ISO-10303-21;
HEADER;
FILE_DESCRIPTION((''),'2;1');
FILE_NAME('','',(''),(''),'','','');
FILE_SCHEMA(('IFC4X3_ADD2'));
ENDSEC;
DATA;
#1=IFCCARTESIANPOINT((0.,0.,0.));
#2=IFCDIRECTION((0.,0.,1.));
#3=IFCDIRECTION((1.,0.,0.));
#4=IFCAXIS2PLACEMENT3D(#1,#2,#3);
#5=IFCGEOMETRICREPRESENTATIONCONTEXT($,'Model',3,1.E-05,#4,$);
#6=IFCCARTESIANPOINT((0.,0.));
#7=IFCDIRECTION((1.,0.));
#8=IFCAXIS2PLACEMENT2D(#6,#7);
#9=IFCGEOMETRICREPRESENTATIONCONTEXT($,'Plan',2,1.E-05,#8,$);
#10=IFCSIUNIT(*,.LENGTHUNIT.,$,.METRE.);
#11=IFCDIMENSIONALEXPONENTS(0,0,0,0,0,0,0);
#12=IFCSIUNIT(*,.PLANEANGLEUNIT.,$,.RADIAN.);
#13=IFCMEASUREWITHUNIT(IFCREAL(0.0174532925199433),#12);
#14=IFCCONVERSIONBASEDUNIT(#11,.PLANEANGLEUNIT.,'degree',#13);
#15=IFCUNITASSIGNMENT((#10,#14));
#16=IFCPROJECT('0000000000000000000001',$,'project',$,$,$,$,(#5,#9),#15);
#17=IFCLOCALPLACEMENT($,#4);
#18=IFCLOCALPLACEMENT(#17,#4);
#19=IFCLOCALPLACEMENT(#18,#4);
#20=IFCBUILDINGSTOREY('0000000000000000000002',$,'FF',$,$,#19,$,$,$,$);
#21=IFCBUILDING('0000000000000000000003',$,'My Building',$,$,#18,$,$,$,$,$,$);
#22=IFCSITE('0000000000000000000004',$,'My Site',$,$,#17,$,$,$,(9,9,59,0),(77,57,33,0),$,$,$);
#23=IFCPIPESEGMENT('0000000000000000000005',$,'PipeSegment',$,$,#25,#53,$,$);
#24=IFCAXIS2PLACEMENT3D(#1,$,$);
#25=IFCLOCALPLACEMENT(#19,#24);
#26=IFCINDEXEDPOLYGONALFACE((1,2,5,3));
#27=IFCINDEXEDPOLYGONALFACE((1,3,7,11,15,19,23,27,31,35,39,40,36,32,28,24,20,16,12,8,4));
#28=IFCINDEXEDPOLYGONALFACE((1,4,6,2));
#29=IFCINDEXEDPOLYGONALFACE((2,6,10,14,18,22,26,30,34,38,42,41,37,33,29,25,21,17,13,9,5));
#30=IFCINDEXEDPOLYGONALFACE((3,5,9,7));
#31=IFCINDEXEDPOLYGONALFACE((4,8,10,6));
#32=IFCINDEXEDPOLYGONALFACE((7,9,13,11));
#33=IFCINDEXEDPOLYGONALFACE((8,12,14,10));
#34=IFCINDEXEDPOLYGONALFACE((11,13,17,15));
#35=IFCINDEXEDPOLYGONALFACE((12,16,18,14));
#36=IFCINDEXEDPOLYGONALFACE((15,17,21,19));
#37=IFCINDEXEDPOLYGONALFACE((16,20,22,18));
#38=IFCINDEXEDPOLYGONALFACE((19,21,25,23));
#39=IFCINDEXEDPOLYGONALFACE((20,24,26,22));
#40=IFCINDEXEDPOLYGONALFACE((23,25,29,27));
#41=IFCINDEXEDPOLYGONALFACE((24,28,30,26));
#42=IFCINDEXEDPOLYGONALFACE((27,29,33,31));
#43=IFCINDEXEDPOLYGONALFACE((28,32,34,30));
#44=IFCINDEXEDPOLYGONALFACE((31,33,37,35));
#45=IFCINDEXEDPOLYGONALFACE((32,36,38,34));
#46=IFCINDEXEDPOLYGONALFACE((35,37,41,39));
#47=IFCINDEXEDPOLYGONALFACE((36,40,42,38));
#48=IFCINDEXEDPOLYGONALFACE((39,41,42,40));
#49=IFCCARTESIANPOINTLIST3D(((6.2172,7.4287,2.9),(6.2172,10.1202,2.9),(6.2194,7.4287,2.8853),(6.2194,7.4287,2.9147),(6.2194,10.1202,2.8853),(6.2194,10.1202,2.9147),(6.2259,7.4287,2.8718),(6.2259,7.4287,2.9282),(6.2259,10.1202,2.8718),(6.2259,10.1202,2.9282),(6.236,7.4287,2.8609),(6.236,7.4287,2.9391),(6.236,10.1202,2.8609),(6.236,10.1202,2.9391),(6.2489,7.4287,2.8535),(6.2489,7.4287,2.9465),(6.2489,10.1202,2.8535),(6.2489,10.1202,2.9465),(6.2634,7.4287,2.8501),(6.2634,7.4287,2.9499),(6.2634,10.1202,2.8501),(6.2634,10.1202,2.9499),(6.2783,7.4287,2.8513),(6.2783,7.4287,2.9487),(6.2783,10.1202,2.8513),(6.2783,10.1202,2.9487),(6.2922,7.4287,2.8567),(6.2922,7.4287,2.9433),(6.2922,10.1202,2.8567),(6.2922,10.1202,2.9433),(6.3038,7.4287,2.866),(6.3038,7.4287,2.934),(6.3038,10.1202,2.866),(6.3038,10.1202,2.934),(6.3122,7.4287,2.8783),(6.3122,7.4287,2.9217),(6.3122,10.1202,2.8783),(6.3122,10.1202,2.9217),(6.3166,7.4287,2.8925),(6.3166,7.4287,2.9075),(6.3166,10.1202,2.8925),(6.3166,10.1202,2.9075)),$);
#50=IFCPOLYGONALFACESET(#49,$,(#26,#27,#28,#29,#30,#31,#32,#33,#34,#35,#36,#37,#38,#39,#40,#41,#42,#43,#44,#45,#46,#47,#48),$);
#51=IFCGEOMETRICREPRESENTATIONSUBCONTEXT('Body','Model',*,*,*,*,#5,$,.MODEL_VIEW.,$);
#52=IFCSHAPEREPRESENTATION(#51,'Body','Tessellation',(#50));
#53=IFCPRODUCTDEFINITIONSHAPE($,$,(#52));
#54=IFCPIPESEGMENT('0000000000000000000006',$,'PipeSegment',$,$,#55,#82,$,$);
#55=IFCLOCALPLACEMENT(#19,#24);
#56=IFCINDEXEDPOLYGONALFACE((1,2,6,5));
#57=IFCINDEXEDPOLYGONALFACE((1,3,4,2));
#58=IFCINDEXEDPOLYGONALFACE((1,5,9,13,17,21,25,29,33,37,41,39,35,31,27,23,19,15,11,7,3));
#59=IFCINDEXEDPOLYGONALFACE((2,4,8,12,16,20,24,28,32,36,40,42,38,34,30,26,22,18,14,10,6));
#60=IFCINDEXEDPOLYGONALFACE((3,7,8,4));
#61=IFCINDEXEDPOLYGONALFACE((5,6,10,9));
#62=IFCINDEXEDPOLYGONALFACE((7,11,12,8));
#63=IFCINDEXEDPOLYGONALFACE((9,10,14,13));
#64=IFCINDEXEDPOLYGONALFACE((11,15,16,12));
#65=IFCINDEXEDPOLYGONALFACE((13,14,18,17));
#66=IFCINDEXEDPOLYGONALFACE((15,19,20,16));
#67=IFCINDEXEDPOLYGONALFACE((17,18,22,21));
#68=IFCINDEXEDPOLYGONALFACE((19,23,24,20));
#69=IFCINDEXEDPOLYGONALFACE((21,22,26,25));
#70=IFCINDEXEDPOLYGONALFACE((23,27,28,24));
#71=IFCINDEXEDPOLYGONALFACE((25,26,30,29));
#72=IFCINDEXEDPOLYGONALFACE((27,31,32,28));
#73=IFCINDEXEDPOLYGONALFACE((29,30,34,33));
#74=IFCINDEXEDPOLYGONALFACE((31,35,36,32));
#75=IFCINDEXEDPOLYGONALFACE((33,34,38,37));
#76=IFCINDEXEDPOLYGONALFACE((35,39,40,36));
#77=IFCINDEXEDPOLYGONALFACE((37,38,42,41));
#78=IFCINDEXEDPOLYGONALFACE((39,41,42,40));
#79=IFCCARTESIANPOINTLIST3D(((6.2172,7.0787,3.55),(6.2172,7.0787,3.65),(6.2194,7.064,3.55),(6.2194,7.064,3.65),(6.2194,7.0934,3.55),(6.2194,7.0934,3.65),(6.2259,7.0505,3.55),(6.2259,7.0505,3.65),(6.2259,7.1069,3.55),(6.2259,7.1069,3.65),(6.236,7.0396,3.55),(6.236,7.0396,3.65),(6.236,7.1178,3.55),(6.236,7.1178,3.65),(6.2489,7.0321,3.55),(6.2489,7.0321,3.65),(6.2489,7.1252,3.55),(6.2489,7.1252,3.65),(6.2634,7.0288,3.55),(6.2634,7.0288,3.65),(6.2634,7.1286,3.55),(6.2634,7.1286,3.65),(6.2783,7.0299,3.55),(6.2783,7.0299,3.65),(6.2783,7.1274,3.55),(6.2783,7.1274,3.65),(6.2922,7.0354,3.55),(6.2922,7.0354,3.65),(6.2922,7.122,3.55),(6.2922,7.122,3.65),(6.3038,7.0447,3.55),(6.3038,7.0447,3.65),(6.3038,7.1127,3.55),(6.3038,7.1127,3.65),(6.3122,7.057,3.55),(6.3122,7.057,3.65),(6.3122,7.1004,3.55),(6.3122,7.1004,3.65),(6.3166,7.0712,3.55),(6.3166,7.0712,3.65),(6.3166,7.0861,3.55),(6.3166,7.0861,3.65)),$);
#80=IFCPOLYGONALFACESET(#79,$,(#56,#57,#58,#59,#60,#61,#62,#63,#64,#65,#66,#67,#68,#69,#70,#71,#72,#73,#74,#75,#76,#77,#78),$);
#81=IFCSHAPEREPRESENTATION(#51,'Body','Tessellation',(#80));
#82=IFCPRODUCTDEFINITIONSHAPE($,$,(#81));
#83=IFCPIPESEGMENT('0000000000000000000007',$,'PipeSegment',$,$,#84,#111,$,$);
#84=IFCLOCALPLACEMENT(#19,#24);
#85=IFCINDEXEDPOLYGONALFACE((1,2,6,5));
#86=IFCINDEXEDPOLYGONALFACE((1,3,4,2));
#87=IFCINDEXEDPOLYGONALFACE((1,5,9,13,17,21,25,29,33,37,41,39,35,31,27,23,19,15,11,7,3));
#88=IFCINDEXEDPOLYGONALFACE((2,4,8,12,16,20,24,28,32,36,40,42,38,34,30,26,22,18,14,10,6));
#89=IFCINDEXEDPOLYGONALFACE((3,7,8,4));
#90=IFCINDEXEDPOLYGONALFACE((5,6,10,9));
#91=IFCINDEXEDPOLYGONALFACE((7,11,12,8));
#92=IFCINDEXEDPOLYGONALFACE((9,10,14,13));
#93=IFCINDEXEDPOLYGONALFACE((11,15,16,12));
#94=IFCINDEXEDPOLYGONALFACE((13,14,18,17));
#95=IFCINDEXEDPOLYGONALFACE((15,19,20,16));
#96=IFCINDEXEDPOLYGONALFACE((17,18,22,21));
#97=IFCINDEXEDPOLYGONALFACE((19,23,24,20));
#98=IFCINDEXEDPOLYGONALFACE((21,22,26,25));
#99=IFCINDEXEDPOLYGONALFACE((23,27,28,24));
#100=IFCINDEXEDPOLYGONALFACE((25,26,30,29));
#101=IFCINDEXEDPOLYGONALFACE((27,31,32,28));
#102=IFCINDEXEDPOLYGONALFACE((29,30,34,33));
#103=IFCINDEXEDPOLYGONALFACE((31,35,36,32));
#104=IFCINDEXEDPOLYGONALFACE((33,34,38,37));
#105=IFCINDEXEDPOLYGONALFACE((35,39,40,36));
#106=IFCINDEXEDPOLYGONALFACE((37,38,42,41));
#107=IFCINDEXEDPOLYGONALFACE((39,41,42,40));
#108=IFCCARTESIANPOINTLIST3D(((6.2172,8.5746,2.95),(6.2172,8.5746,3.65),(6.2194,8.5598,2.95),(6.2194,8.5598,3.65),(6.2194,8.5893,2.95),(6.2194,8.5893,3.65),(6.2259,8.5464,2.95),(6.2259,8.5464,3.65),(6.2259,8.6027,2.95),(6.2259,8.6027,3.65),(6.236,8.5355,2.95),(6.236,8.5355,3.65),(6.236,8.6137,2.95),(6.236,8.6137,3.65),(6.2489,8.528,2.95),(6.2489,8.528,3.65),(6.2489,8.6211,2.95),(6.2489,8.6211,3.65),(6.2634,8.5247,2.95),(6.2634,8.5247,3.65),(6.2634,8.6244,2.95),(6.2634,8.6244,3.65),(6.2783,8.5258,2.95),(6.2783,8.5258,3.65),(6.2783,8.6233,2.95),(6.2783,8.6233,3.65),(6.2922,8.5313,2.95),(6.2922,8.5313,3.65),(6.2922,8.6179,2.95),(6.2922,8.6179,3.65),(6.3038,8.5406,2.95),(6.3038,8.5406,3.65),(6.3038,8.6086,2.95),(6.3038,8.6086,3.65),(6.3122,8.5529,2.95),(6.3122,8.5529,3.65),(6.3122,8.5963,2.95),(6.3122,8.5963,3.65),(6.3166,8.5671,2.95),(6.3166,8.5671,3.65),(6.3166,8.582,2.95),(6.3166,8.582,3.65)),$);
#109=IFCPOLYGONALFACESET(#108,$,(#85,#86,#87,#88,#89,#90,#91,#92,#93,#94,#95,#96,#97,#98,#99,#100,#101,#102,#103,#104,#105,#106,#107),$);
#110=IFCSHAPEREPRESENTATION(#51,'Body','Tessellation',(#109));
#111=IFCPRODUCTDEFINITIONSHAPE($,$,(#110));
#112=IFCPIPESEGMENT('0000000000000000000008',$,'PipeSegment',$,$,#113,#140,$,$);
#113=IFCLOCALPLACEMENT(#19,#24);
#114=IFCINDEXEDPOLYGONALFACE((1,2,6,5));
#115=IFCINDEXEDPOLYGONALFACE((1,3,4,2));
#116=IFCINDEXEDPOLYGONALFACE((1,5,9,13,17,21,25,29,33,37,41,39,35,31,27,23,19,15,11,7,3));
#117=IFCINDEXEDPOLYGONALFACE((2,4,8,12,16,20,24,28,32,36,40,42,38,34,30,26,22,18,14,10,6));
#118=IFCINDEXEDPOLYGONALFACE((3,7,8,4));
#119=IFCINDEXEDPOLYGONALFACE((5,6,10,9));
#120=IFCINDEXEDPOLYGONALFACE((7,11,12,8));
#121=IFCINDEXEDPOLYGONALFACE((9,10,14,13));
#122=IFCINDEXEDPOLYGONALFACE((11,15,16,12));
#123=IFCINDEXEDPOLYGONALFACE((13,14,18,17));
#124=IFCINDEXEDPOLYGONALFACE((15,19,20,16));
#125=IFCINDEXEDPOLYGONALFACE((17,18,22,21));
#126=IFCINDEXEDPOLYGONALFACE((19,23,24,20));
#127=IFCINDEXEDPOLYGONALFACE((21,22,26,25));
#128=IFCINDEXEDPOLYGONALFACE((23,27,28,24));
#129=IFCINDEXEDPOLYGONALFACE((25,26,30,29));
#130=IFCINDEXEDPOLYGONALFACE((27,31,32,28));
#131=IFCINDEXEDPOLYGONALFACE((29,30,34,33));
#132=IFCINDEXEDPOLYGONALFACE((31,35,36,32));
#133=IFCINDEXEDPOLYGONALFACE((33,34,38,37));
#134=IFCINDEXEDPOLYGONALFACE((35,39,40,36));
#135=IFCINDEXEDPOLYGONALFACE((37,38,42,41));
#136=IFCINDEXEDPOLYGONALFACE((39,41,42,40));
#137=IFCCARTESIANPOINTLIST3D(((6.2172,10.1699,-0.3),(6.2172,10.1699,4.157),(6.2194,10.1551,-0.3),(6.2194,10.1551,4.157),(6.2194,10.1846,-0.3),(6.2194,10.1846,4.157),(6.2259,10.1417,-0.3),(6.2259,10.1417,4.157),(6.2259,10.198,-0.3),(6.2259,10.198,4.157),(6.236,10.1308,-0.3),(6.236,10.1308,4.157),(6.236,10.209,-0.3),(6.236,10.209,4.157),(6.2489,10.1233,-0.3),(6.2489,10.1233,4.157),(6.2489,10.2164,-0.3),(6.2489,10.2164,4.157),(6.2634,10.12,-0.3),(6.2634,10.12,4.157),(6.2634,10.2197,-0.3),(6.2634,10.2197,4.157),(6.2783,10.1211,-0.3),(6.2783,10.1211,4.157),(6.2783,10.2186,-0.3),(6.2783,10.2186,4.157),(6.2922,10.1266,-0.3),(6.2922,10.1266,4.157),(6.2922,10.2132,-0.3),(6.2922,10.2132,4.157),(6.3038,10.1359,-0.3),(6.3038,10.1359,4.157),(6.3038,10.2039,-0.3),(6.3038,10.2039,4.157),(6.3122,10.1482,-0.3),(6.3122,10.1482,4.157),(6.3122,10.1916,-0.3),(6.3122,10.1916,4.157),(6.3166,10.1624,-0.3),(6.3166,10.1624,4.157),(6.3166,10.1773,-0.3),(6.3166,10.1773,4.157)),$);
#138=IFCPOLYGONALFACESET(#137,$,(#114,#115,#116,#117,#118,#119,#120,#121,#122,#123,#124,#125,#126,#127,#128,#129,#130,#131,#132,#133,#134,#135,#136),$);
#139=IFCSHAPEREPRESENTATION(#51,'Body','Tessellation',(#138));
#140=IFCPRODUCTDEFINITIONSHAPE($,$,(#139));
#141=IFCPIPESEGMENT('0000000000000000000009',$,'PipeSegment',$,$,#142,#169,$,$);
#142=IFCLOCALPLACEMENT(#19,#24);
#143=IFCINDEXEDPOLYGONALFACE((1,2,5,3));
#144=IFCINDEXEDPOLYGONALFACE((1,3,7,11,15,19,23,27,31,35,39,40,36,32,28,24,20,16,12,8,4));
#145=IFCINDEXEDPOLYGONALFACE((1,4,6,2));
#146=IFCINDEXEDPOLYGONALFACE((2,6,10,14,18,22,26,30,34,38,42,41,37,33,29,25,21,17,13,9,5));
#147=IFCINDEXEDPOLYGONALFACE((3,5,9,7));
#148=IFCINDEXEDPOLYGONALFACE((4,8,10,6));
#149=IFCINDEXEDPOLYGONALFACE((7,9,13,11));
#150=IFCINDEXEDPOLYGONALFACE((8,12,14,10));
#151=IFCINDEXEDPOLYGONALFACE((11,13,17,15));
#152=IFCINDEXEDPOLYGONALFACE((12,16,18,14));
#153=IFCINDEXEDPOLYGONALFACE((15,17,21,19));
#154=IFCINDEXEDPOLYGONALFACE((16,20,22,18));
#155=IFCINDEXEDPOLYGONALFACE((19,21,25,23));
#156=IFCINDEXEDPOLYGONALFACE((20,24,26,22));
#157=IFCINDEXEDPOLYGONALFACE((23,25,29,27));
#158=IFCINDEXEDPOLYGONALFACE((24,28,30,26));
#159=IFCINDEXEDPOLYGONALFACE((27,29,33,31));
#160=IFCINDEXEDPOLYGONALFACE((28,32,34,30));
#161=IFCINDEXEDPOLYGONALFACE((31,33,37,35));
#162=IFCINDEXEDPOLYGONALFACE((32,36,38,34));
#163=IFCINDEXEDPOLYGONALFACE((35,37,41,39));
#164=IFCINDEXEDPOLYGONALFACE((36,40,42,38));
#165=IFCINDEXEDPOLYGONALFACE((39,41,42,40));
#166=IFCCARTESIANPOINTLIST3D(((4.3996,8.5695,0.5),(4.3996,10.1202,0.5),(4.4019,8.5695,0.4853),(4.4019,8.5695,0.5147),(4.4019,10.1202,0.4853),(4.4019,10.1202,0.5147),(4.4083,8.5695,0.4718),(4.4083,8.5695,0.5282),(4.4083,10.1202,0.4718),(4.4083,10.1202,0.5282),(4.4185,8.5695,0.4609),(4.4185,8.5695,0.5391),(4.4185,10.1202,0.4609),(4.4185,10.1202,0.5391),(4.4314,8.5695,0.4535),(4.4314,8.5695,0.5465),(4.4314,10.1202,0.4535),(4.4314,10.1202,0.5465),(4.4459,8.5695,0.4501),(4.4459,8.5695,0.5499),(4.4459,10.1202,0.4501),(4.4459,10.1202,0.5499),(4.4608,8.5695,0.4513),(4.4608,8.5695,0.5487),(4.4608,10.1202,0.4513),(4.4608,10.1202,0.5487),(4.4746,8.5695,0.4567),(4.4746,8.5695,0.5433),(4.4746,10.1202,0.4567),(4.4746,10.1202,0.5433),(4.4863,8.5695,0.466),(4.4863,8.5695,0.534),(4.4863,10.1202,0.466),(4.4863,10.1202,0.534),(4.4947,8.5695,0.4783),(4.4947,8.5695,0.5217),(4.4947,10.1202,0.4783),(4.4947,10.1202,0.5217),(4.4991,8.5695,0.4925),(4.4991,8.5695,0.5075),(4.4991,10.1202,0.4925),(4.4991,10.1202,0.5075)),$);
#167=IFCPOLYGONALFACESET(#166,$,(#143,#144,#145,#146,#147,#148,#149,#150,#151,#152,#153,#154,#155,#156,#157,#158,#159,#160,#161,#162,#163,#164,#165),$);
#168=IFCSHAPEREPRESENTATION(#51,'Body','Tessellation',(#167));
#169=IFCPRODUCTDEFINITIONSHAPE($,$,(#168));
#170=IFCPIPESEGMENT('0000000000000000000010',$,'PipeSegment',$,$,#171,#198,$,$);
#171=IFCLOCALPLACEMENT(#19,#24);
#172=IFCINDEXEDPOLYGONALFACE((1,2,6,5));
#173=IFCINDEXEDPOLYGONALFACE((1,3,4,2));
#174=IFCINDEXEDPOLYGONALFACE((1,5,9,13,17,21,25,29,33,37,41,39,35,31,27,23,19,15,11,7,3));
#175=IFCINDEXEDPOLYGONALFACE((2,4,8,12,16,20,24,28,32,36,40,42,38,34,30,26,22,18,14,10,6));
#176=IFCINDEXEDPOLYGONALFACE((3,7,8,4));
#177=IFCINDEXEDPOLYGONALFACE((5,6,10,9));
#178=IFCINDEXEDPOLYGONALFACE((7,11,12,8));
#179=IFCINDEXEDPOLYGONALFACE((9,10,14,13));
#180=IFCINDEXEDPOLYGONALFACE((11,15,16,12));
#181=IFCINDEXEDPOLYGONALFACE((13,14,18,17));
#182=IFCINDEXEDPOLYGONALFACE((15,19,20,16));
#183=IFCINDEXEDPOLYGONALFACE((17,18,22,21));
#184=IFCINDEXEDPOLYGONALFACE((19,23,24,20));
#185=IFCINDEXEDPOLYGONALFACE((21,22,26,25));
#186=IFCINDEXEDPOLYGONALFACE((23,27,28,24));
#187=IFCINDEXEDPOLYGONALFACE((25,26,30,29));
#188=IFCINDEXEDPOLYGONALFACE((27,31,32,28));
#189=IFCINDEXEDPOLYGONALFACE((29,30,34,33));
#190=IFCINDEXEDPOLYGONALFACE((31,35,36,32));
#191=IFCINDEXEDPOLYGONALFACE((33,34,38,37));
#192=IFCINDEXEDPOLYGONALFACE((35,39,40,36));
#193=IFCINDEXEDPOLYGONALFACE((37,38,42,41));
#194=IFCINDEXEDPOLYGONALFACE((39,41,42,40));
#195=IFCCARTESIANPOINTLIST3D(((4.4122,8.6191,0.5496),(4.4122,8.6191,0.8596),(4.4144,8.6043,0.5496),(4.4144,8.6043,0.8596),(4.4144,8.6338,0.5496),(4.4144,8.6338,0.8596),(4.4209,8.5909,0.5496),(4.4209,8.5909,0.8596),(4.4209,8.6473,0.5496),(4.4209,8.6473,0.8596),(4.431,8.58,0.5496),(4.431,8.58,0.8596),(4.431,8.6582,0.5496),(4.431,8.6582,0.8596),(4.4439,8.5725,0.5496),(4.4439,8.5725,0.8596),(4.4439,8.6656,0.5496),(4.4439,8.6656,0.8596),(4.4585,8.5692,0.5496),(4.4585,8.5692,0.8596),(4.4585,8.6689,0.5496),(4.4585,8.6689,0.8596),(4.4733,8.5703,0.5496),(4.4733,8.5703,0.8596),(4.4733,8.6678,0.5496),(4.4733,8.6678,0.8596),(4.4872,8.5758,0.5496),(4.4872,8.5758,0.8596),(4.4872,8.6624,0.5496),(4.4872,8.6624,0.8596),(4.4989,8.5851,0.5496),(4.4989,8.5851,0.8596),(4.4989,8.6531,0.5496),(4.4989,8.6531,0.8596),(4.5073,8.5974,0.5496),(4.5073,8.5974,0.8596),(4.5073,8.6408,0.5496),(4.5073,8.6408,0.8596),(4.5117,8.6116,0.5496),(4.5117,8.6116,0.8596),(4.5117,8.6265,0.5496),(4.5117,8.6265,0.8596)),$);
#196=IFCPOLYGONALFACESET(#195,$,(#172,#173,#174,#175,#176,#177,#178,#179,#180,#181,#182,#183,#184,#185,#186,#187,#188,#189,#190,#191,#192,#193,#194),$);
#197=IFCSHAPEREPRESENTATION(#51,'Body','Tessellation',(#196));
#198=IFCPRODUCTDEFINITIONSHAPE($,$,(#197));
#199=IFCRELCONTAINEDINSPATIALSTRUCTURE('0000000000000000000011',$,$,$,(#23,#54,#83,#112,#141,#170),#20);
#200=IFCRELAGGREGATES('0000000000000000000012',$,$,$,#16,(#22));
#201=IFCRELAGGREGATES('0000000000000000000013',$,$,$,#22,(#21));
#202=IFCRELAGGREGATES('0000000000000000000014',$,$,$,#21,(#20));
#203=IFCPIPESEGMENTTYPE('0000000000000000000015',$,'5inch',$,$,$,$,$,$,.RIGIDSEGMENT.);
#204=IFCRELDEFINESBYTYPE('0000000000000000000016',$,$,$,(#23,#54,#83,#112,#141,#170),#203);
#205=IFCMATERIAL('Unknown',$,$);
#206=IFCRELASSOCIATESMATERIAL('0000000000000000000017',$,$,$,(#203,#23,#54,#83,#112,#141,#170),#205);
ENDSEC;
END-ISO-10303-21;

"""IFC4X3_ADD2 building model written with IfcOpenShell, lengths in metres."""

from ifc_helpers import new_model, entity, si_unit, converted_unit, frame, origin_with_axes, origin_2d_with_axis, place, context, subcontext, project, spatial, circle, extrude, material, material_profile, profile_set, profile_usage, type_object, element, save


model = new_model("IFC4X3_ADD2")

# Units and contexts
model_context = context("Model", 3, precision=1e-05, world=origin_with_axes())
plan_context = context("Plan", 2, precision=1e-05, world=origin_2d_with_axis())
body_context_1 = subcontext(model_context, "Body", "Model", "MODEL_VIEW")
ifc_project = project(units=[si_unit("LENGTHUNIT", "METRE"), converted_unit("PLANEANGLEUNIT", "degree", entity("IfcReal", 0.0174532925199433), si_unit("PLANEANGLEUNIT", "RADIAN"), dimensions=[0, 0, 0, 0, 0, 0, 0])], contexts=[model_context, plan_context])

# Site, building, storey
site_placement = place(None, origin_with_axes())
site = spatial("IfcSite", under=ifc_project, at=site_placement, Name="My Site", RefLatitude=(9, 9, 59, 0), RefLongitude=(77, 57, 33, 0))
building_placement = place(site_placement, origin_with_axes())
building = spatial("IfcBuilding", under=site, at=building_placement, Name="My Building")
storey_placement = place(building_placement, origin_with_axes())
storey = spatial("IfcBuildingStorey", under=building, at=storey_placement, Name="FF")

# Shared definitions
ifc_material = material(Name="Unknown")

# Pipe segments
ifc_material_profile_1 = material_profile(ifc_material, circle(Radius=0.05))
ifc_profile_set_1 = profile_set([ifc_material_profile_1])
ifc_profile_usage_1 = profile_usage(ifc_profile_set_1, cardinal=5)
pipe_segment_type_1 = type_object("IfcPipeSegmentType", Name="5inch", PredefinedType="RIGIDSEGMENT", material=ifc_profile_set_1)
pipe_segment_1_placement = place(storey_placement, frame((6.2672, 7.4287, 2.9), z_axis=(0.0, 1.0, 0.0), x_axis=(-1.0, 0.0, 0.0)))
element("IfcPipeSegment", 1, at=pipe_segment_1_placement, inside=storey, type_object=pipe_segment_type_1, material=ifc_profile_usage_1, Name="PipeSegment", context=body_context_1, shape_type="SweptSolid", body=[
    extrude(circle(Radius=0.05), origin_with_axes(), (0.0, 0.0, 1.0), 2.6915),
])
ifc_profile_usage_2 = profile_usage(ifc_profile_set_1, cardinal=5)
pipe_segment_2_placement = place(storey_placement, frame((6.2672, 7.0787, 3.55), z_axis=(0.0, 0.0, 1.0), x_axis=(-1.0, 0.0, 0.0)))
element("IfcPipeSegment", 2, at=pipe_segment_2_placement, inside=storey, type_object=pipe_segment_type_1, material=ifc_profile_usage_2, Name="PipeSegment", context=body_context_1, shape_type="SweptSolid", body=[
    extrude(circle(Radius=0.05), origin_with_axes(), (0.0, 0.0, 1.0), 0.1),
])
ifc_profile_usage_3 = profile_usage(ifc_profile_set_1, cardinal=5)
pipe_segment_3_placement = place(storey_placement, frame((6.2672, 8.5746, 2.95), z_axis=(0.0, 0.0, 1.0), x_axis=(-1.0, 0.0, 0.0)))
element("IfcPipeSegment", 3, at=pipe_segment_3_placement, inside=storey, type_object=pipe_segment_type_1, material=ifc_profile_usage_3, Name="PipeSegment", context=body_context_1, shape_type="SweptSolid", body=[
    extrude(circle(Radius=0.05), origin_with_axes(), (0.0, 0.0, 1.0), 0.7),
])
ifc_profile_usage_4 = profile_usage(ifc_profile_set_1, cardinal=5)
pipe_segment_4_placement = place(storey_placement, frame((6.2672, 10.1699, -0.3), z_axis=(0.0, 0.0, 1.0), x_axis=(-1.0, 0.0, 0.0)))
element("IfcPipeSegment", 4, at=pipe_segment_4_placement, inside=storey, type_object=pipe_segment_type_1, material=ifc_profile_usage_4, Name="PipeSegment", context=body_context_1, shape_type="SweptSolid", body=[
    extrude(circle(Radius=0.05), origin_with_axes(), (0.0, 0.0, 1.0), 4.457),
])
ifc_profile_usage_5 = profile_usage(ifc_profile_set_1, cardinal=5)
pipe_segment_5_placement = place(storey_placement, frame((4.4496, 8.5695, 0.5), z_axis=(0.0, 1.0, 0.0), x_axis=(-1.0, 0.0, 0.0)))
element("IfcPipeSegment", 5, at=pipe_segment_5_placement, inside=storey, type_object=pipe_segment_type_1, material=ifc_profile_usage_5, Name="PipeSegment", context=body_context_1, shape_type="SweptSolid", body=[
    extrude(circle(Radius=0.05), origin_with_axes(), (0.0, 0.0, 1.0), 1.5508),
])
ifc_profile_usage_6 = profile_usage(ifc_profile_set_1, cardinal=5)
pipe_segment_6_placement = place(storey_placement, frame((4.4622, 8.6191, 0.5496), z_axis=(0.0, 0.0, 1.0), x_axis=(-1.0, 0.0, 0.0)))
element("IfcPipeSegment", 6, at=pipe_segment_6_placement, inside=storey, type_object=pipe_segment_type_1, material=ifc_profile_usage_6, Name="PipeSegment", context=body_context_1, shape_type="SweptSolid", body=[
    extrude(circle(Radius=0.05), origin_with_axes(), (0.0, 0.0, 1.0), 0.3099),
])

save(model, "model.ifc")
